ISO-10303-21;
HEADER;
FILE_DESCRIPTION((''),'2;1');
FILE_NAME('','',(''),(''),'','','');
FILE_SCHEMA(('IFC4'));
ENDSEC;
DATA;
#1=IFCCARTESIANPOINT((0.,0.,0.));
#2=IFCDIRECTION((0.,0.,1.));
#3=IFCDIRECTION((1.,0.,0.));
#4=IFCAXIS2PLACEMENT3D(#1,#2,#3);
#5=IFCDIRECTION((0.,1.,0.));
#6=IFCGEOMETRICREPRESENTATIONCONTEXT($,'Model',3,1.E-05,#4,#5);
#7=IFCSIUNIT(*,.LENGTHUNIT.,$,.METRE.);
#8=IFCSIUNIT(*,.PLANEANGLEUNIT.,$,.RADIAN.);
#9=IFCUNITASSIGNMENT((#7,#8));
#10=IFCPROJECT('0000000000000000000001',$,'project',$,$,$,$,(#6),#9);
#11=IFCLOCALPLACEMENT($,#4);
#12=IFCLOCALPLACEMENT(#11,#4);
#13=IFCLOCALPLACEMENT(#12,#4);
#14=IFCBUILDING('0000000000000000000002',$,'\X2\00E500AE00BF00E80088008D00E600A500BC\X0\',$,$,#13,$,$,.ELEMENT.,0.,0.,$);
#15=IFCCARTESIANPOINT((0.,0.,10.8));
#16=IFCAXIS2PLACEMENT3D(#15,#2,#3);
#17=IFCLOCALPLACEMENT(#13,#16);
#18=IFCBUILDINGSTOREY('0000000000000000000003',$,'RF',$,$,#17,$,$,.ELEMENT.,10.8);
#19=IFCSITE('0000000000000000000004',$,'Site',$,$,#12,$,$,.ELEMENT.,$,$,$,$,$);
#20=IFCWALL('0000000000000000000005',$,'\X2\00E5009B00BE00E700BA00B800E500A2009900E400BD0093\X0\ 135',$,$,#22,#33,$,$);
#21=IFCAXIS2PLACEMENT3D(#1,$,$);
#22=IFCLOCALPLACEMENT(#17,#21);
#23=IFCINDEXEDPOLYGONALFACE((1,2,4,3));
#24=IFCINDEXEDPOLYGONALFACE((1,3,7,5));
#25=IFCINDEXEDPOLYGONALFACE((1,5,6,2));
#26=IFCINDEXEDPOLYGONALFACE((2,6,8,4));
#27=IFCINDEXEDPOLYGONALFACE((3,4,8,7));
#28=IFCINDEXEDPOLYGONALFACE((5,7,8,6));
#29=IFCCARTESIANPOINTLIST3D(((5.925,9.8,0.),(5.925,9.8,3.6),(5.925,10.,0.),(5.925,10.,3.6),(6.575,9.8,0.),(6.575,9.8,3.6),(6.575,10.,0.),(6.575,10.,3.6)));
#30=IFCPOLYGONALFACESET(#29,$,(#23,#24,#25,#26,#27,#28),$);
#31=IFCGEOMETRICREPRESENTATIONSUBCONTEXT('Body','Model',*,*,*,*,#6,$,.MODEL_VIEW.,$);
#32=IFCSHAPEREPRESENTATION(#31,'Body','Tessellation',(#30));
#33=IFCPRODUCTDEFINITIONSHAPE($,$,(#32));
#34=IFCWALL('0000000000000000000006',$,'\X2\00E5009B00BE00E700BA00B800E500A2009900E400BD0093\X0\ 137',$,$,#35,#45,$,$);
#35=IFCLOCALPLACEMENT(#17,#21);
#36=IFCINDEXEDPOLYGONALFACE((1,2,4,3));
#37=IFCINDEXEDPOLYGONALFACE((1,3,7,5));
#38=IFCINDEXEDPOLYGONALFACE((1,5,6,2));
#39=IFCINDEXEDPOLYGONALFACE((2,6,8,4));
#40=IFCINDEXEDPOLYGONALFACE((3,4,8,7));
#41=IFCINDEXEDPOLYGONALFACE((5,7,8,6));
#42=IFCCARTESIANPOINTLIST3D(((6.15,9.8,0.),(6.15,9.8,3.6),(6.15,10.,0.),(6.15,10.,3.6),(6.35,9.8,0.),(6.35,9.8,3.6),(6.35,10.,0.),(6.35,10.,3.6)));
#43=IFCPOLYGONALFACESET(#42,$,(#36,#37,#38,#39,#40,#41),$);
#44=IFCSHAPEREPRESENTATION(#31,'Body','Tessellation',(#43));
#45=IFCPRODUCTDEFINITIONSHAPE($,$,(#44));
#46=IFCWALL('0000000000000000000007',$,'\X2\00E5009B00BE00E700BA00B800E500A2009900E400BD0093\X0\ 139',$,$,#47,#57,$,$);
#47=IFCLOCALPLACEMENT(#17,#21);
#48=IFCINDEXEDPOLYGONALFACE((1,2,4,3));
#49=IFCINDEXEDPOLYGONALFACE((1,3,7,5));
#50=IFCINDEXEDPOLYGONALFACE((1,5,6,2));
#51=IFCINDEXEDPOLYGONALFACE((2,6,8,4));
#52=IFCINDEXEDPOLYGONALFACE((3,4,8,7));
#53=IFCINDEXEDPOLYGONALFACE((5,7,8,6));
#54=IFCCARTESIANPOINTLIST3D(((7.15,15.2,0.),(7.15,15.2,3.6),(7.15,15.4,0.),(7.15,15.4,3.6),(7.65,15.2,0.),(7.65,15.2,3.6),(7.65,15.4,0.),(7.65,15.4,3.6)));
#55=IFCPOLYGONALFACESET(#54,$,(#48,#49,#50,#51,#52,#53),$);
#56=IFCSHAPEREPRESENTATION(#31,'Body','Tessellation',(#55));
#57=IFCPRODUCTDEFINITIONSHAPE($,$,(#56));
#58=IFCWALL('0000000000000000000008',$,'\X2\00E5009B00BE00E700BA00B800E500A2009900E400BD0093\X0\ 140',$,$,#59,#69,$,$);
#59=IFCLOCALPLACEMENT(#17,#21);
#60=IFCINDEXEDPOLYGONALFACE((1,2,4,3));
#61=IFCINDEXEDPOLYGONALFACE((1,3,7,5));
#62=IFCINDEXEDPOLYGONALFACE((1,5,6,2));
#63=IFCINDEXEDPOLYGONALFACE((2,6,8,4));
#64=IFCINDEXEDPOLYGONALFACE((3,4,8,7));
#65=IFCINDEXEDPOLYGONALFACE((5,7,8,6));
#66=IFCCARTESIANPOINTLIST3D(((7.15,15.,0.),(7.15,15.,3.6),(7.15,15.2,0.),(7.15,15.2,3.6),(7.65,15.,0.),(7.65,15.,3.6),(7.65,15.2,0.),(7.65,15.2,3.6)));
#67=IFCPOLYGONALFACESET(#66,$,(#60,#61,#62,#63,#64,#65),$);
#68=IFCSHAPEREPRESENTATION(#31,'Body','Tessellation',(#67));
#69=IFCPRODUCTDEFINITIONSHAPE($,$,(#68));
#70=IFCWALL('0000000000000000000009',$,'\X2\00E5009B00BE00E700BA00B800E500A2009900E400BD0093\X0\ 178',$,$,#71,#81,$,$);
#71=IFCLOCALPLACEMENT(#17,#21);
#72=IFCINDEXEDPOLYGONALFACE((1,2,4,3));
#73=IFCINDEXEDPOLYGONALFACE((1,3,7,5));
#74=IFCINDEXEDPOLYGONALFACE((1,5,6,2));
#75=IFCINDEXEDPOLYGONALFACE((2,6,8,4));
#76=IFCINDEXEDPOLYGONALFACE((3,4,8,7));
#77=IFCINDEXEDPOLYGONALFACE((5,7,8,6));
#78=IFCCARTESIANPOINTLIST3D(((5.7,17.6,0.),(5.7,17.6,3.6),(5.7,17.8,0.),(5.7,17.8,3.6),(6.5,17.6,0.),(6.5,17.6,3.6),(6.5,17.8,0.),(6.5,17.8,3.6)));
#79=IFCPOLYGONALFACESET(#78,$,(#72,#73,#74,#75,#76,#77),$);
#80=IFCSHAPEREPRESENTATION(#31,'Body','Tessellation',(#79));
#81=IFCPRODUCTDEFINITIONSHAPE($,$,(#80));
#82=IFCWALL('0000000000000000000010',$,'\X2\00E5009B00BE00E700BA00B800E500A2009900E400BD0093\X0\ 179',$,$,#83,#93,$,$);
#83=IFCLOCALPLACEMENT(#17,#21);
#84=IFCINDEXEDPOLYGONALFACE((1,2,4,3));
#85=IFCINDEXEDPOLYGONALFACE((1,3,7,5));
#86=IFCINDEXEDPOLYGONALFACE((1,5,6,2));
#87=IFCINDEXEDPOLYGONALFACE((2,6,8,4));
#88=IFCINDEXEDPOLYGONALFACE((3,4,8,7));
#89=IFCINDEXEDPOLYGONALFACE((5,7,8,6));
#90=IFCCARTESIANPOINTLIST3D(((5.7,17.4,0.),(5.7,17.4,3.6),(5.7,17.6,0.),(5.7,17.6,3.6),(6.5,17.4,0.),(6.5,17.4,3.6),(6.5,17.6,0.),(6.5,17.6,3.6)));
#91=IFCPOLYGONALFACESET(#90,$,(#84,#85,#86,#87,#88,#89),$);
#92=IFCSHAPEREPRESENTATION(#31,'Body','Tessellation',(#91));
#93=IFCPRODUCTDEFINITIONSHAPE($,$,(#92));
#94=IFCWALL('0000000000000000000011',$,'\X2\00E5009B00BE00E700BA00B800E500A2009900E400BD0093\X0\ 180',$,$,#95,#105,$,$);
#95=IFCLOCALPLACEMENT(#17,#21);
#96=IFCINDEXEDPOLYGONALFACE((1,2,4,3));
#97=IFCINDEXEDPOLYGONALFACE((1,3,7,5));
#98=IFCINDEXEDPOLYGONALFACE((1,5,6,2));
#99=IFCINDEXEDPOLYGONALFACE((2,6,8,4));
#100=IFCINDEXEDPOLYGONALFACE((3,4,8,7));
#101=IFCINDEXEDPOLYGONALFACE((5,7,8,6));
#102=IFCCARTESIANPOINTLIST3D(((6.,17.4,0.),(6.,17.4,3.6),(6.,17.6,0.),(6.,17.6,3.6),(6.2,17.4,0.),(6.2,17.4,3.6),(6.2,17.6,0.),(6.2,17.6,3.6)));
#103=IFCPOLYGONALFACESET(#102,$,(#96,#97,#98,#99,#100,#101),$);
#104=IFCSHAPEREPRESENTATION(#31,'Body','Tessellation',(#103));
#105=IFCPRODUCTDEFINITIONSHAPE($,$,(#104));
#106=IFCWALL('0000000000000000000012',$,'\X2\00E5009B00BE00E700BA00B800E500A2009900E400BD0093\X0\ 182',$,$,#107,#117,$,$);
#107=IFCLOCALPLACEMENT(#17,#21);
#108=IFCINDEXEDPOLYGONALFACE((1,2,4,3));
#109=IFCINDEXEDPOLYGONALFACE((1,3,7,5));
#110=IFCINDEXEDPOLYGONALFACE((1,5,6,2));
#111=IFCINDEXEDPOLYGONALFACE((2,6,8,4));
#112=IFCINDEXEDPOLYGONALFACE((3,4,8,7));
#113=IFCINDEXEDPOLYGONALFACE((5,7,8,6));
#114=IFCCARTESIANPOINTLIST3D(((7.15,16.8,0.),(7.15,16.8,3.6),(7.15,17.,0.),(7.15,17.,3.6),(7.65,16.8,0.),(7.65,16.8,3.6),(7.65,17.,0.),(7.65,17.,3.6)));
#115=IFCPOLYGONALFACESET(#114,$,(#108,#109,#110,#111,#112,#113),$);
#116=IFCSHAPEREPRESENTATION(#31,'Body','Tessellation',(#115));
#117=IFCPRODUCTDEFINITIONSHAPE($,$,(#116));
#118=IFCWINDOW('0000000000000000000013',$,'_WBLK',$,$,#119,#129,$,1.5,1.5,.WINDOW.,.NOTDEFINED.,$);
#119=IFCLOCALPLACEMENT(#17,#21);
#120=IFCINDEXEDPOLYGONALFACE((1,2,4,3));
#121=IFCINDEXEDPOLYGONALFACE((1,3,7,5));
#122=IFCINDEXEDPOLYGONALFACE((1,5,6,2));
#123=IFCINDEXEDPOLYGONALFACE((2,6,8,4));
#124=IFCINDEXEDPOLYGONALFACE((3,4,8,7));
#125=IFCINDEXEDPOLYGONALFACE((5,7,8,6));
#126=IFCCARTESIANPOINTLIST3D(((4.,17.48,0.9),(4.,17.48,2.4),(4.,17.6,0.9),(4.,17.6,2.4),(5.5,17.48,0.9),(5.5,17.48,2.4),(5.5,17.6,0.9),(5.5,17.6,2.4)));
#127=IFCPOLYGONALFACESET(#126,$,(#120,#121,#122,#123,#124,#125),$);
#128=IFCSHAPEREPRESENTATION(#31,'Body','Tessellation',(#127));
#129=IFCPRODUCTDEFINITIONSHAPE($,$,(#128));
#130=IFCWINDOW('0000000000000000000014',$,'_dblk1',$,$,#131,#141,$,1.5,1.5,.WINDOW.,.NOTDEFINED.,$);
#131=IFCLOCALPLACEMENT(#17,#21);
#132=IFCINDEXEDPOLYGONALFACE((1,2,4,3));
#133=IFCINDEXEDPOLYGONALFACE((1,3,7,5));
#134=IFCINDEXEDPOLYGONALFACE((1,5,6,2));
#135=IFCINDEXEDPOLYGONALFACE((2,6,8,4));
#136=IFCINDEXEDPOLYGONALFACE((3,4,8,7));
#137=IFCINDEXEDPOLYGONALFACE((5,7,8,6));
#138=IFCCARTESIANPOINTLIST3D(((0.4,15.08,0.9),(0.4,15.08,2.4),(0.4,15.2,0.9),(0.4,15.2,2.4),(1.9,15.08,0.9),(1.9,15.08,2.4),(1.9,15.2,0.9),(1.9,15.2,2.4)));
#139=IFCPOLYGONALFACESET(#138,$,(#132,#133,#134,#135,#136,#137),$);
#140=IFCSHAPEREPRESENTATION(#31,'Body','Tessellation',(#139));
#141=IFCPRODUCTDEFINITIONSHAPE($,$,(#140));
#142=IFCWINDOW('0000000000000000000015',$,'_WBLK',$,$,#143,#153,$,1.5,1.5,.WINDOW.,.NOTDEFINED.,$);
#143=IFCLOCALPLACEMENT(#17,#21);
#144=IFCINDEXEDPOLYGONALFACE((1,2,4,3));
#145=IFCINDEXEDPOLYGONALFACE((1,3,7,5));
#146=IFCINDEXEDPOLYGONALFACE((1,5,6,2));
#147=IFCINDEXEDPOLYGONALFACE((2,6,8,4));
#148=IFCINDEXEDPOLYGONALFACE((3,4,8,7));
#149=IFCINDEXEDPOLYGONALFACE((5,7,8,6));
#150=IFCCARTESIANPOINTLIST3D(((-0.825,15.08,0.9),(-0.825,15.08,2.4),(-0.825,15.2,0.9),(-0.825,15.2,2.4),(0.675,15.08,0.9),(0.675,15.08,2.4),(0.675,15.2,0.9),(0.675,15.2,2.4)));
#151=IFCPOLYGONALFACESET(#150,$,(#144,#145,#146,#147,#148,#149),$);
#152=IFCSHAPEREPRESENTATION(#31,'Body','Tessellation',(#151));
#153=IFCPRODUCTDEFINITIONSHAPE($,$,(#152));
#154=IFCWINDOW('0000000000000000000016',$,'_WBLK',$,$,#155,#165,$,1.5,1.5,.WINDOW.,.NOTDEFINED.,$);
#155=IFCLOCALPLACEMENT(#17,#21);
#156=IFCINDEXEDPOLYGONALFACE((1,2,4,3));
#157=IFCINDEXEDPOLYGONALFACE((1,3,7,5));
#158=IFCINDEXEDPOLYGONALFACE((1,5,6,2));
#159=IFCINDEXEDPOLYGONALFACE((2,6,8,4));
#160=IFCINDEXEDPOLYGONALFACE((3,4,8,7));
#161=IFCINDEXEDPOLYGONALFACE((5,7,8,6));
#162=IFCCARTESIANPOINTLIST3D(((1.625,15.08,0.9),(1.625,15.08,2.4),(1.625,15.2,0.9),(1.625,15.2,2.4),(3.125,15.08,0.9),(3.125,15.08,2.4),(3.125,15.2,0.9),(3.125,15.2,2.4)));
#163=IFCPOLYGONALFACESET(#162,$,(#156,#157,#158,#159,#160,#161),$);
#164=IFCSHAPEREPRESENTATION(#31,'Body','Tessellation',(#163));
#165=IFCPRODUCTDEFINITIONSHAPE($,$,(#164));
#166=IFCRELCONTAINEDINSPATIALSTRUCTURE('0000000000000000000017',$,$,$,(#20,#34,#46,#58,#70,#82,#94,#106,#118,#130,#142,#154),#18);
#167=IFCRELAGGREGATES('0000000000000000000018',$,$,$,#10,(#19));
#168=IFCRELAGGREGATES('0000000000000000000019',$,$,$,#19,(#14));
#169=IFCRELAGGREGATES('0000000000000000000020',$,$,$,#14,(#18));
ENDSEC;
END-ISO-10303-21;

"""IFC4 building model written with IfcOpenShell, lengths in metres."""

from ifc_helpers import new_model, si_unit, direction, frame, frame_2d, origin_with_axes, place, context, subcontext, project, spatial, rectangle, extrude, element, save


model = new_model("IFC4")

# Units and contexts
model_context = context("Model", 3, precision=1e-05, world=origin_with_axes(), true_north=direction((0.0, 1.0, 0.0)))
body_context = subcontext(model_context, "Body", "Model", "MODEL_VIEW")
ifc_project = project(units=[si_unit("LENGTHUNIT", "METRE"), si_unit("PLANEANGLEUNIT", "RADIAN")], contexts=[model_context])

# Site, building, storey
placement = place(None, origin_with_axes())
site_placement = place(placement, origin_with_axes())
site = spatial("IfcSite", under=ifc_project, at=site_placement, Name="Site", CompositionType="ELEMENT")
building_placement = place(site_placement, origin_with_axes())
building = spatial("IfcBuilding", under=site, at=building_placement, Name="å®¿è\u0088\u008dæ¥¼", CompositionType="ELEMENT", ElevationOfRefHeight=0.0, ElevationOfTerrain=0.0)
storey_placement = place(building_placement, frame((0.0, 0.0, 10.8), z_axis=(0.0, 0.0, 1.0), x_axis=(1.0, 0.0, 0.0)))
storey = spatial("IfcBuildingStorey", under=building, at=storey_placement, Name="RF", CompositionType="ELEMENT", Elevation=10.8)

# Walls
wall_1_placement = place(storey_placement, frame((6.25, 9.9, 0.0), z_axis=(0.0, 0.0, 1.0), x_axis=(1.0, 0.0, 0.0)))
element("IfcWall", 1, at=wall_1_placement, inside=storey, Name="å\u009b¾çº¸å¢\u0099ä½\u0093 135", context=body_context, shape_type="SweptSolid", body=[
    extrude(rectangle(XDim=0.65, YDim=0.2, at=frame_2d((0.0, 0.0), x_axis=(1.0, 0.0, 0.0))), frame((0.0, 0.0, 0.0), z_axis=(0.0, 0.0, 1.0)), (0.0, 0.0, 1.0), 3.6),
])
wall_2_placement = place(storey_placement, frame((6.25, 9.9, 0.0), z_axis=(0.0, 0.0, 1.0), x_axis=(0.0, -1.0, 0.0)))
element("IfcWall", 2, at=wall_2_placement, inside=storey, Name="å\u009b¾çº¸å¢\u0099ä½\u0093 137", context=body_context, shape_type="SweptSolid", body=[
    extrude(rectangle(XDim=0.2, YDim=0.2, at=frame_2d((0.0, 0.0), x_axis=(1.0, 0.0, 0.0))), frame((0.0, 0.0, 0.0), z_axis=(0.0, 0.0, 1.0)), (0.0, 0.0, 1.0), 3.6),
])
for number, where, z_axis, x_axis, name in (
    (3, (7.4, 15.3, 0.0), (0.0, 0.0, 1.0), (1.0, 0.0, 0.0), "å\u009b¾çº¸å¢\u0099ä½\u0093 139"),
    (4, (7.4, 15.1, 0.0), (0.0, 0.0, 1.0), (1.0, 0.0, 0.0), "å\u009b¾çº¸å¢\u0099ä½\u0093 140"),
):
    element("IfcWall", number, at=place(storey_placement, frame(where, z_axis=z_axis, x_axis=x_axis)), inside=storey, Name=name, context=body_context, shape_type="SweptSolid", body=[
        extrude(rectangle(XDim=0.5, YDim=0.2, at=frame_2d((0.0, 0.0), x_axis=(1.0, 0.0, 0.0))), frame((0.0, 0.0, 0.0), z_axis=(0.0, 0.0, 1.0)), (0.0, 0.0, 1.0), 3.6),
    ])
for number, where, z_axis, x_axis, name in (
    (5, (6.1, 17.7, 0.0), (0.0, 0.0, 1.0), (1.0, 0.0, 0.0), "å\u009b¾çº¸å¢\u0099ä½\u0093 178"),
    (6, (6.1, 17.5, 0.0), (0.0, 0.0, 1.0), (1.0, 0.0, 0.0), "å\u009b¾çº¸å¢\u0099ä½\u0093 179"),
):
    element("IfcWall", number, at=place(storey_placement, frame(where, z_axis=z_axis, x_axis=x_axis)), inside=storey, Name=name, context=body_context, shape_type="SweptSolid", body=[
        extrude(rectangle(XDim=0.8, YDim=0.2, at=frame_2d((0.0, 0.0), x_axis=(1.0, 0.0, 0.0))), frame((0.0, 0.0, 0.0), z_axis=(0.0, 0.0, 1.0)), (0.0, 0.0, 1.0), 3.6),
    ])
wall_3_placement = place(storey_placement, frame((6.1, 17.5, 0.0), z_axis=(0.0, 0.0, 1.0), x_axis=(0.0, 1.0, 0.0)))
element("IfcWall", 7, at=wall_3_placement, inside=storey, Name="å\u009b¾çº¸å¢\u0099ä½\u0093 180", context=body_context, shape_type="SweptSolid", body=[
    extrude(rectangle(XDim=0.2, YDim=0.2, at=frame_2d((0.0, 0.0), x_axis=(1.0, 0.0, 0.0))), frame((0.0, 0.0, 0.0), z_axis=(0.0, 0.0, 1.0)), (0.0, 0.0, 1.0), 3.6),
])
wall_4_placement = place(storey_placement, frame((7.4, 16.9, 0.0), z_axis=(0.0, 0.0, 1.0), x_axis=(1.0, 0.0, 0.0)))
element("IfcWall", 8, at=wall_4_placement, inside=storey, Name="å\u009b¾çº¸å¢\u0099ä½\u0093 182", context=body_context, shape_type="SweptSolid", body=[
    extrude(rectangle(XDim=0.5, YDim=0.2, at=frame_2d((0.0, 0.0), x_axis=(1.0, 0.0, 0.0))), frame((0.0, 0.0, 0.0), z_axis=(0.0, 0.0, 1.0)), (0.0, 0.0, 1.0), 3.6),
])

# Windows
for number, where, z_axis, x_axis, name in (
    (9, (4.75, 17.54, 0.9), (0.0, 0.0, 1.0), (1.0, 0.0, 0.0), "_WBLK"),
    (10, (1.15, 15.14, 0.9), (0.0, 0.0, 1.0), (1.0, 0.0, 0.0), "_dblk1"),
    (11, (-0.075, 15.14, 0.9), (0.0, 0.0, 1.0), (1.0, 0.0, 0.0), "_WBLK"),
    (12, (2.375, 15.14, 0.9), (0.0, 0.0, 1.0), (1.0, 0.0, 0.0), "_WBLK"),
):
    element("IfcWindow", number, at=place(storey_placement, frame(where, z_axis=z_axis, x_axis=x_axis)), inside=storey, Name=name, OverallHeight=1.5, OverallWidth=1.5, PartitioningType="NOTDEFINED", PredefinedType="WINDOW", context=body_context, shape_type="SweptSolid", body=[
        extrude(rectangle(XDim=1.5, YDim=0.12, at=frame_2d((0.0, 0.0), x_axis=(1.0, 0.0, 0.0))), frame((0.0, 0.0, 0.0), z_axis=(0.0, 0.0, 1.0)), (0.0, 0.0, 1.0), 1.5),
    ])

save(model, "model.ifc")
